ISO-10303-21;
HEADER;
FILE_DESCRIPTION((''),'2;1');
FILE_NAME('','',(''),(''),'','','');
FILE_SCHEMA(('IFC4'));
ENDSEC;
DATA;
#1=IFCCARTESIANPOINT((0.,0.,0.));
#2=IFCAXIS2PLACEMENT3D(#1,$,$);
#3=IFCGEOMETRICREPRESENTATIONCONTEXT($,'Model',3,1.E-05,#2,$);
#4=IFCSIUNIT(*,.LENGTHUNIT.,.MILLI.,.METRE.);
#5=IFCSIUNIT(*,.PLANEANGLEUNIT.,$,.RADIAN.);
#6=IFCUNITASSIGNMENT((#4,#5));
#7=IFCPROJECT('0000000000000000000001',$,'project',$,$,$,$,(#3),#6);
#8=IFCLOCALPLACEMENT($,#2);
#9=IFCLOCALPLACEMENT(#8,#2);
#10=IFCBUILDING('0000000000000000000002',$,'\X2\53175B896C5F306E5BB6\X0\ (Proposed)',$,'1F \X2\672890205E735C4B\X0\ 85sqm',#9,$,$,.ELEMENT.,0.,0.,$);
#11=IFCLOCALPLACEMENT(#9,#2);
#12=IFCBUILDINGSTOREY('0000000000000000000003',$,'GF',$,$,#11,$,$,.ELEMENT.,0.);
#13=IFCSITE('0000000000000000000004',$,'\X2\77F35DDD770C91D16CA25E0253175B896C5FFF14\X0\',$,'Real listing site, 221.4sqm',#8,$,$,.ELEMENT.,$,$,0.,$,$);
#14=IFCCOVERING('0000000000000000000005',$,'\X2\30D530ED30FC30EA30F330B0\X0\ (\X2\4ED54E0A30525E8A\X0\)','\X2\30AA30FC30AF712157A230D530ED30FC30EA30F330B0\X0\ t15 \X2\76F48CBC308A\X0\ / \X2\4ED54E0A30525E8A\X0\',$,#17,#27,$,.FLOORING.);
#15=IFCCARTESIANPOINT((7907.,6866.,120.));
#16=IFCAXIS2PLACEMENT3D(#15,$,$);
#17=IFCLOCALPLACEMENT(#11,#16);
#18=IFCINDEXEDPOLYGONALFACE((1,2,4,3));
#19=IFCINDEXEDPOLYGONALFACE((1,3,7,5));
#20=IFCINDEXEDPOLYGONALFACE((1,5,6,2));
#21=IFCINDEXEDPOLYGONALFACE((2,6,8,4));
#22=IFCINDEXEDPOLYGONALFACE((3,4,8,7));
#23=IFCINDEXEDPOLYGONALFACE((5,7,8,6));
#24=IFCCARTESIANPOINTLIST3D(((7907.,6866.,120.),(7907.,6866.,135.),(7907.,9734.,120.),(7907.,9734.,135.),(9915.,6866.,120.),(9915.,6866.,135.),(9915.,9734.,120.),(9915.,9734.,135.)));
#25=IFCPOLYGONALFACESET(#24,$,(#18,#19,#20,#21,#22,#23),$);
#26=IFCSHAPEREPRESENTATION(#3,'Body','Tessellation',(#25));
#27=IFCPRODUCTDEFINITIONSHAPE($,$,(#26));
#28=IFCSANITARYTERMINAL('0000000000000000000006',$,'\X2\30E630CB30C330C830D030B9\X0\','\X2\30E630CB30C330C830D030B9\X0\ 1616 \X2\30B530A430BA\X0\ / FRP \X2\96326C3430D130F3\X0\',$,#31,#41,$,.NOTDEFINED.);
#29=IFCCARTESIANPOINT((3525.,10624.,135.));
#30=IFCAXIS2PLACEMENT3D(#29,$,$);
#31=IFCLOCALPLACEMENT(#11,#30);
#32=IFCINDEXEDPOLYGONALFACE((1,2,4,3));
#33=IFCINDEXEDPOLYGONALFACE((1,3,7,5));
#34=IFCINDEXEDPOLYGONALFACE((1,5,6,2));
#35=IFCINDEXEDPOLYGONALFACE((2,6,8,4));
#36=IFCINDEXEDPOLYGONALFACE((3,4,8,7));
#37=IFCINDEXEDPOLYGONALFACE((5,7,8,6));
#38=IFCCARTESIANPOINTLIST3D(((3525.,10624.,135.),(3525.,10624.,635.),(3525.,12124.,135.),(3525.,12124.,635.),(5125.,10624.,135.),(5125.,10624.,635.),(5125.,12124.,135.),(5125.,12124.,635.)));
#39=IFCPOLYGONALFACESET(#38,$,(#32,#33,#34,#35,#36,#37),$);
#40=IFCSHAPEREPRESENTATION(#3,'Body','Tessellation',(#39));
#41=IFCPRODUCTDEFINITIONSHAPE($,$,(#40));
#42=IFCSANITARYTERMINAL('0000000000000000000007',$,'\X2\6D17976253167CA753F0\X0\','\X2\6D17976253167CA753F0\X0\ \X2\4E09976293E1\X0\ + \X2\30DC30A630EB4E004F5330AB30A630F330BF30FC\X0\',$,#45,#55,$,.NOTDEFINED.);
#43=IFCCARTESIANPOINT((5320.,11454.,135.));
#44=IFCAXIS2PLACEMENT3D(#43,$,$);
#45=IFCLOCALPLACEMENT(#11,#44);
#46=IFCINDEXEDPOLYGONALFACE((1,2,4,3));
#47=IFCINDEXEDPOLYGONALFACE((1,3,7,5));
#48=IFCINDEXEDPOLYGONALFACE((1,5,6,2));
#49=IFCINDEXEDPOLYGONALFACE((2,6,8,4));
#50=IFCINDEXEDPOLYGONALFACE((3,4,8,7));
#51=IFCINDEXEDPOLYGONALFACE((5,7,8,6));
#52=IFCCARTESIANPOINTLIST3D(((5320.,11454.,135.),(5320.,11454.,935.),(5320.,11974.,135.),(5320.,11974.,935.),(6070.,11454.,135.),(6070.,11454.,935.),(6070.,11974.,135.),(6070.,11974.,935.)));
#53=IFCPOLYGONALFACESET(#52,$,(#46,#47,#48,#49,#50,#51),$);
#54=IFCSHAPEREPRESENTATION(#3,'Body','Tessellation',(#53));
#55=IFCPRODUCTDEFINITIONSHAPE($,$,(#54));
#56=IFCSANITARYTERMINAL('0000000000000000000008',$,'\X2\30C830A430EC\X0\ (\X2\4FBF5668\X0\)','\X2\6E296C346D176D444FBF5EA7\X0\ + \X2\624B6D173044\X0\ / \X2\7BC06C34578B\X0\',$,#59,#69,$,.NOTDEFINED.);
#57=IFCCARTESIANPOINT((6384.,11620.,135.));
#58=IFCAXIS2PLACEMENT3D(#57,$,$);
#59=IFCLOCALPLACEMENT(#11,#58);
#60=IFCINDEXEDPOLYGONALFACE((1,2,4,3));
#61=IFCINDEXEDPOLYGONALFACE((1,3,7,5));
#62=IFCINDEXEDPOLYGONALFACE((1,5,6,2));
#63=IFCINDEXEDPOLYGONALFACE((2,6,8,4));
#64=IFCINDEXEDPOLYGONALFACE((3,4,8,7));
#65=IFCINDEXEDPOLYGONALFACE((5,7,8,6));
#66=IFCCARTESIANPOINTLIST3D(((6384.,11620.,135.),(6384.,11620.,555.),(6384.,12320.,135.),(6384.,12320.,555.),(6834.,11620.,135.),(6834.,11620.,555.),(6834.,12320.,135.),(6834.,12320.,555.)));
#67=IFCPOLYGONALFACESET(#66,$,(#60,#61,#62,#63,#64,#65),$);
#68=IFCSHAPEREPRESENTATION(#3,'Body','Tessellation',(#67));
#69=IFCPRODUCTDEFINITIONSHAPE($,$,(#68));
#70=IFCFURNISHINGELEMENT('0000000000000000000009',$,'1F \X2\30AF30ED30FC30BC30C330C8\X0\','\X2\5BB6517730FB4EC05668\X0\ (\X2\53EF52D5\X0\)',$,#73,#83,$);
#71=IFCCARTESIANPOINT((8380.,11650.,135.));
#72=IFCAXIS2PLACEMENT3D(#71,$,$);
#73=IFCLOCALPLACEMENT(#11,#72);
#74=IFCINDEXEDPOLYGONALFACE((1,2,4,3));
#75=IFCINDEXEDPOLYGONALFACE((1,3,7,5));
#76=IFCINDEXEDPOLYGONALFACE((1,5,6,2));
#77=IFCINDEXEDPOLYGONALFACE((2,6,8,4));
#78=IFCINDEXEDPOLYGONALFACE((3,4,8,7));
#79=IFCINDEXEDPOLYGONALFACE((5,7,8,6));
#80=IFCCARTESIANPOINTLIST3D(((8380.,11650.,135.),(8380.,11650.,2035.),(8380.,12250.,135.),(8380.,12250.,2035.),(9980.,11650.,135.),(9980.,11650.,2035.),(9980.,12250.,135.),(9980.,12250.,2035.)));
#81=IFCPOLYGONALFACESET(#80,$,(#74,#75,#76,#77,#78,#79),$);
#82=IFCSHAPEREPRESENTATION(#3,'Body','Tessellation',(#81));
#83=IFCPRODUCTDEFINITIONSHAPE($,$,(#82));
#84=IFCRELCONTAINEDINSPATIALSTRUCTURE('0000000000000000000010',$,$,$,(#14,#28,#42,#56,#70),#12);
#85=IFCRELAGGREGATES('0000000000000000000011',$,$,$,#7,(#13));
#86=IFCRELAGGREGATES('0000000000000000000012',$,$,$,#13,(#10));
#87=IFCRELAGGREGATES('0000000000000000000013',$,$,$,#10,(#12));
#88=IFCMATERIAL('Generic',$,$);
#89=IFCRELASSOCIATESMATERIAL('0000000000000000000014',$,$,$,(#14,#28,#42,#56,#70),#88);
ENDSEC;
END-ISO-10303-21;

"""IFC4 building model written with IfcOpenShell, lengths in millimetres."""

from ifc_helpers import new_model, si_unit, frame, frame_2d, origin, place, context, project, spatial, rectangle, extrude, material, element, save


model = new_model("IFC4")

# Units and contexts
model_context = context("Model", 3, precision=1e-05, world=origin())
ifc_project = project(units=[si_unit("LENGTHUNIT", "METRE", prefix="MILLI"), si_unit("PLANEANGLEUNIT", "RADIAN")], contexts=[model_context])

# Site, building, storey
site_placement = place(None, origin())
site = spatial("IfcSite", under=ifc_project, at=site_placement, Name="石川県金沢市北安江４", ObjectType="Real listing site, 221.4sqm", CompositionType="ELEMENT", RefElevation=0.0)
building_placement = place(site_placement, origin())
building = spatial("IfcBuilding", under=site, at=building_placement, Name="北安江の家 (Proposed)", ObjectType="1F 木造平屋 85sqm", CompositionType="ELEMENT", ElevationOfRefHeight=0.0, ElevationOfTerrain=0.0)
storey_placement = place(building_placement, origin())
storey = spatial("IfcBuildingStorey", under=building, at=storey_placement, Name="GF", CompositionType="ELEMENT", Elevation=0.0)

# Covering
ifc_material_1 = material(Name="Generic")
covering_1_placement = place(storey_placement, frame((7907.0, 6866.0, 120.0)))
element("IfcCovering", 1, at=covering_1_placement, inside=storey, material=ifc_material_1, Name="フローリング (仕上げ床)", Description="オーク無垢フローリング t15 直貼り / 仕上げ床", PredefinedType="FLOORING", context=model_context, shape_type="SweptSolid", body=[
    extrude(rectangle(XDim=2008.0, YDim=2868.0, at=frame_2d((1004.0, 1434.0))), frame((7907.0, 6866.0, 120.0)), (0.0, 0.0, 1.0), 15.0),
])

# Sanitary terminals
sanitary_terminal_1_placement = place(storey_placement, frame((3525.0, 10624.0, 135.0)))
element("IfcSanitaryTerminal", 2, at=sanitary_terminal_1_placement, inside=storey, material=ifc_material_1, Name="ユニットバス", Description="ユニットバス 1616 サイズ / FRP 防水パン", PredefinedType="NOTDEFINED", context=model_context, shape_type="SweptSolid", body=[
    extrude(rectangle(XDim=1600.0, YDim=1500.0, at=frame_2d((800.0, 750.0))), frame((3525.0, 10624.0, 135.0)), (0.0, 0.0, 1.0), 500.0),
])
sanitary_terminal_2_placement = place(storey_placement, frame((5320.0, 11454.0, 135.0)))
element("IfcSanitaryTerminal", 3, at=sanitary_terminal_2_placement, inside=storey, material=ifc_material_1, Name="洗面化粧台", Description="洗面化粧台 三面鏡 + ボウル一体カウンター", PredefinedType="NOTDEFINED", context=model_context, shape_type="SweptSolid", body=[
    extrude(rectangle(XDim=750.0, YDim=520.0, at=frame_2d((375.0, 260.0))), frame((5320.0, 11454.0, 135.0)), (0.0, 0.0, 1.0), 800.0),
])
sanitary_terminal_3_placement = place(storey_placement, frame((6384.0, 11620.0, 135.0)))
element("IfcSanitaryTerminal", 4, at=sanitary_terminal_3_placement, inside=storey, material=ifc_material_1, Name="トイレ (便器)", Description="温水洗浄便座 + 手洗い / 節水型", PredefinedType="NOTDEFINED", context=model_context, shape_type="SweptSolid", body=[
    extrude(rectangle(XDim=450.0, YDim=700.0, at=frame_2d((225.0, 350.0))), frame((6384.0, 11620.0, 135.0)), (0.0, 0.0, 1.0), 420.0),
])

# Furnishing element
furnishing_placement = place(storey_placement, frame((8380.0, 11650.0, 135.0)))
element("IfcFurnishingElement", 5, at=furnishing_placement, inside=storey, material=ifc_material_1, Name="1F クローゼット", Description="家具・什器 (可動)", context=model_context, shape_type="SweptSolid", body=[
    extrude(rectangle(XDim=1600.0, YDim=600.0, at=frame_2d((800.0, 300.0))), frame((8380.0, 11650.0, 135.0)), (0.0, 0.0, 1.0), 1900.0),
])

save(model, "model.ifc")
